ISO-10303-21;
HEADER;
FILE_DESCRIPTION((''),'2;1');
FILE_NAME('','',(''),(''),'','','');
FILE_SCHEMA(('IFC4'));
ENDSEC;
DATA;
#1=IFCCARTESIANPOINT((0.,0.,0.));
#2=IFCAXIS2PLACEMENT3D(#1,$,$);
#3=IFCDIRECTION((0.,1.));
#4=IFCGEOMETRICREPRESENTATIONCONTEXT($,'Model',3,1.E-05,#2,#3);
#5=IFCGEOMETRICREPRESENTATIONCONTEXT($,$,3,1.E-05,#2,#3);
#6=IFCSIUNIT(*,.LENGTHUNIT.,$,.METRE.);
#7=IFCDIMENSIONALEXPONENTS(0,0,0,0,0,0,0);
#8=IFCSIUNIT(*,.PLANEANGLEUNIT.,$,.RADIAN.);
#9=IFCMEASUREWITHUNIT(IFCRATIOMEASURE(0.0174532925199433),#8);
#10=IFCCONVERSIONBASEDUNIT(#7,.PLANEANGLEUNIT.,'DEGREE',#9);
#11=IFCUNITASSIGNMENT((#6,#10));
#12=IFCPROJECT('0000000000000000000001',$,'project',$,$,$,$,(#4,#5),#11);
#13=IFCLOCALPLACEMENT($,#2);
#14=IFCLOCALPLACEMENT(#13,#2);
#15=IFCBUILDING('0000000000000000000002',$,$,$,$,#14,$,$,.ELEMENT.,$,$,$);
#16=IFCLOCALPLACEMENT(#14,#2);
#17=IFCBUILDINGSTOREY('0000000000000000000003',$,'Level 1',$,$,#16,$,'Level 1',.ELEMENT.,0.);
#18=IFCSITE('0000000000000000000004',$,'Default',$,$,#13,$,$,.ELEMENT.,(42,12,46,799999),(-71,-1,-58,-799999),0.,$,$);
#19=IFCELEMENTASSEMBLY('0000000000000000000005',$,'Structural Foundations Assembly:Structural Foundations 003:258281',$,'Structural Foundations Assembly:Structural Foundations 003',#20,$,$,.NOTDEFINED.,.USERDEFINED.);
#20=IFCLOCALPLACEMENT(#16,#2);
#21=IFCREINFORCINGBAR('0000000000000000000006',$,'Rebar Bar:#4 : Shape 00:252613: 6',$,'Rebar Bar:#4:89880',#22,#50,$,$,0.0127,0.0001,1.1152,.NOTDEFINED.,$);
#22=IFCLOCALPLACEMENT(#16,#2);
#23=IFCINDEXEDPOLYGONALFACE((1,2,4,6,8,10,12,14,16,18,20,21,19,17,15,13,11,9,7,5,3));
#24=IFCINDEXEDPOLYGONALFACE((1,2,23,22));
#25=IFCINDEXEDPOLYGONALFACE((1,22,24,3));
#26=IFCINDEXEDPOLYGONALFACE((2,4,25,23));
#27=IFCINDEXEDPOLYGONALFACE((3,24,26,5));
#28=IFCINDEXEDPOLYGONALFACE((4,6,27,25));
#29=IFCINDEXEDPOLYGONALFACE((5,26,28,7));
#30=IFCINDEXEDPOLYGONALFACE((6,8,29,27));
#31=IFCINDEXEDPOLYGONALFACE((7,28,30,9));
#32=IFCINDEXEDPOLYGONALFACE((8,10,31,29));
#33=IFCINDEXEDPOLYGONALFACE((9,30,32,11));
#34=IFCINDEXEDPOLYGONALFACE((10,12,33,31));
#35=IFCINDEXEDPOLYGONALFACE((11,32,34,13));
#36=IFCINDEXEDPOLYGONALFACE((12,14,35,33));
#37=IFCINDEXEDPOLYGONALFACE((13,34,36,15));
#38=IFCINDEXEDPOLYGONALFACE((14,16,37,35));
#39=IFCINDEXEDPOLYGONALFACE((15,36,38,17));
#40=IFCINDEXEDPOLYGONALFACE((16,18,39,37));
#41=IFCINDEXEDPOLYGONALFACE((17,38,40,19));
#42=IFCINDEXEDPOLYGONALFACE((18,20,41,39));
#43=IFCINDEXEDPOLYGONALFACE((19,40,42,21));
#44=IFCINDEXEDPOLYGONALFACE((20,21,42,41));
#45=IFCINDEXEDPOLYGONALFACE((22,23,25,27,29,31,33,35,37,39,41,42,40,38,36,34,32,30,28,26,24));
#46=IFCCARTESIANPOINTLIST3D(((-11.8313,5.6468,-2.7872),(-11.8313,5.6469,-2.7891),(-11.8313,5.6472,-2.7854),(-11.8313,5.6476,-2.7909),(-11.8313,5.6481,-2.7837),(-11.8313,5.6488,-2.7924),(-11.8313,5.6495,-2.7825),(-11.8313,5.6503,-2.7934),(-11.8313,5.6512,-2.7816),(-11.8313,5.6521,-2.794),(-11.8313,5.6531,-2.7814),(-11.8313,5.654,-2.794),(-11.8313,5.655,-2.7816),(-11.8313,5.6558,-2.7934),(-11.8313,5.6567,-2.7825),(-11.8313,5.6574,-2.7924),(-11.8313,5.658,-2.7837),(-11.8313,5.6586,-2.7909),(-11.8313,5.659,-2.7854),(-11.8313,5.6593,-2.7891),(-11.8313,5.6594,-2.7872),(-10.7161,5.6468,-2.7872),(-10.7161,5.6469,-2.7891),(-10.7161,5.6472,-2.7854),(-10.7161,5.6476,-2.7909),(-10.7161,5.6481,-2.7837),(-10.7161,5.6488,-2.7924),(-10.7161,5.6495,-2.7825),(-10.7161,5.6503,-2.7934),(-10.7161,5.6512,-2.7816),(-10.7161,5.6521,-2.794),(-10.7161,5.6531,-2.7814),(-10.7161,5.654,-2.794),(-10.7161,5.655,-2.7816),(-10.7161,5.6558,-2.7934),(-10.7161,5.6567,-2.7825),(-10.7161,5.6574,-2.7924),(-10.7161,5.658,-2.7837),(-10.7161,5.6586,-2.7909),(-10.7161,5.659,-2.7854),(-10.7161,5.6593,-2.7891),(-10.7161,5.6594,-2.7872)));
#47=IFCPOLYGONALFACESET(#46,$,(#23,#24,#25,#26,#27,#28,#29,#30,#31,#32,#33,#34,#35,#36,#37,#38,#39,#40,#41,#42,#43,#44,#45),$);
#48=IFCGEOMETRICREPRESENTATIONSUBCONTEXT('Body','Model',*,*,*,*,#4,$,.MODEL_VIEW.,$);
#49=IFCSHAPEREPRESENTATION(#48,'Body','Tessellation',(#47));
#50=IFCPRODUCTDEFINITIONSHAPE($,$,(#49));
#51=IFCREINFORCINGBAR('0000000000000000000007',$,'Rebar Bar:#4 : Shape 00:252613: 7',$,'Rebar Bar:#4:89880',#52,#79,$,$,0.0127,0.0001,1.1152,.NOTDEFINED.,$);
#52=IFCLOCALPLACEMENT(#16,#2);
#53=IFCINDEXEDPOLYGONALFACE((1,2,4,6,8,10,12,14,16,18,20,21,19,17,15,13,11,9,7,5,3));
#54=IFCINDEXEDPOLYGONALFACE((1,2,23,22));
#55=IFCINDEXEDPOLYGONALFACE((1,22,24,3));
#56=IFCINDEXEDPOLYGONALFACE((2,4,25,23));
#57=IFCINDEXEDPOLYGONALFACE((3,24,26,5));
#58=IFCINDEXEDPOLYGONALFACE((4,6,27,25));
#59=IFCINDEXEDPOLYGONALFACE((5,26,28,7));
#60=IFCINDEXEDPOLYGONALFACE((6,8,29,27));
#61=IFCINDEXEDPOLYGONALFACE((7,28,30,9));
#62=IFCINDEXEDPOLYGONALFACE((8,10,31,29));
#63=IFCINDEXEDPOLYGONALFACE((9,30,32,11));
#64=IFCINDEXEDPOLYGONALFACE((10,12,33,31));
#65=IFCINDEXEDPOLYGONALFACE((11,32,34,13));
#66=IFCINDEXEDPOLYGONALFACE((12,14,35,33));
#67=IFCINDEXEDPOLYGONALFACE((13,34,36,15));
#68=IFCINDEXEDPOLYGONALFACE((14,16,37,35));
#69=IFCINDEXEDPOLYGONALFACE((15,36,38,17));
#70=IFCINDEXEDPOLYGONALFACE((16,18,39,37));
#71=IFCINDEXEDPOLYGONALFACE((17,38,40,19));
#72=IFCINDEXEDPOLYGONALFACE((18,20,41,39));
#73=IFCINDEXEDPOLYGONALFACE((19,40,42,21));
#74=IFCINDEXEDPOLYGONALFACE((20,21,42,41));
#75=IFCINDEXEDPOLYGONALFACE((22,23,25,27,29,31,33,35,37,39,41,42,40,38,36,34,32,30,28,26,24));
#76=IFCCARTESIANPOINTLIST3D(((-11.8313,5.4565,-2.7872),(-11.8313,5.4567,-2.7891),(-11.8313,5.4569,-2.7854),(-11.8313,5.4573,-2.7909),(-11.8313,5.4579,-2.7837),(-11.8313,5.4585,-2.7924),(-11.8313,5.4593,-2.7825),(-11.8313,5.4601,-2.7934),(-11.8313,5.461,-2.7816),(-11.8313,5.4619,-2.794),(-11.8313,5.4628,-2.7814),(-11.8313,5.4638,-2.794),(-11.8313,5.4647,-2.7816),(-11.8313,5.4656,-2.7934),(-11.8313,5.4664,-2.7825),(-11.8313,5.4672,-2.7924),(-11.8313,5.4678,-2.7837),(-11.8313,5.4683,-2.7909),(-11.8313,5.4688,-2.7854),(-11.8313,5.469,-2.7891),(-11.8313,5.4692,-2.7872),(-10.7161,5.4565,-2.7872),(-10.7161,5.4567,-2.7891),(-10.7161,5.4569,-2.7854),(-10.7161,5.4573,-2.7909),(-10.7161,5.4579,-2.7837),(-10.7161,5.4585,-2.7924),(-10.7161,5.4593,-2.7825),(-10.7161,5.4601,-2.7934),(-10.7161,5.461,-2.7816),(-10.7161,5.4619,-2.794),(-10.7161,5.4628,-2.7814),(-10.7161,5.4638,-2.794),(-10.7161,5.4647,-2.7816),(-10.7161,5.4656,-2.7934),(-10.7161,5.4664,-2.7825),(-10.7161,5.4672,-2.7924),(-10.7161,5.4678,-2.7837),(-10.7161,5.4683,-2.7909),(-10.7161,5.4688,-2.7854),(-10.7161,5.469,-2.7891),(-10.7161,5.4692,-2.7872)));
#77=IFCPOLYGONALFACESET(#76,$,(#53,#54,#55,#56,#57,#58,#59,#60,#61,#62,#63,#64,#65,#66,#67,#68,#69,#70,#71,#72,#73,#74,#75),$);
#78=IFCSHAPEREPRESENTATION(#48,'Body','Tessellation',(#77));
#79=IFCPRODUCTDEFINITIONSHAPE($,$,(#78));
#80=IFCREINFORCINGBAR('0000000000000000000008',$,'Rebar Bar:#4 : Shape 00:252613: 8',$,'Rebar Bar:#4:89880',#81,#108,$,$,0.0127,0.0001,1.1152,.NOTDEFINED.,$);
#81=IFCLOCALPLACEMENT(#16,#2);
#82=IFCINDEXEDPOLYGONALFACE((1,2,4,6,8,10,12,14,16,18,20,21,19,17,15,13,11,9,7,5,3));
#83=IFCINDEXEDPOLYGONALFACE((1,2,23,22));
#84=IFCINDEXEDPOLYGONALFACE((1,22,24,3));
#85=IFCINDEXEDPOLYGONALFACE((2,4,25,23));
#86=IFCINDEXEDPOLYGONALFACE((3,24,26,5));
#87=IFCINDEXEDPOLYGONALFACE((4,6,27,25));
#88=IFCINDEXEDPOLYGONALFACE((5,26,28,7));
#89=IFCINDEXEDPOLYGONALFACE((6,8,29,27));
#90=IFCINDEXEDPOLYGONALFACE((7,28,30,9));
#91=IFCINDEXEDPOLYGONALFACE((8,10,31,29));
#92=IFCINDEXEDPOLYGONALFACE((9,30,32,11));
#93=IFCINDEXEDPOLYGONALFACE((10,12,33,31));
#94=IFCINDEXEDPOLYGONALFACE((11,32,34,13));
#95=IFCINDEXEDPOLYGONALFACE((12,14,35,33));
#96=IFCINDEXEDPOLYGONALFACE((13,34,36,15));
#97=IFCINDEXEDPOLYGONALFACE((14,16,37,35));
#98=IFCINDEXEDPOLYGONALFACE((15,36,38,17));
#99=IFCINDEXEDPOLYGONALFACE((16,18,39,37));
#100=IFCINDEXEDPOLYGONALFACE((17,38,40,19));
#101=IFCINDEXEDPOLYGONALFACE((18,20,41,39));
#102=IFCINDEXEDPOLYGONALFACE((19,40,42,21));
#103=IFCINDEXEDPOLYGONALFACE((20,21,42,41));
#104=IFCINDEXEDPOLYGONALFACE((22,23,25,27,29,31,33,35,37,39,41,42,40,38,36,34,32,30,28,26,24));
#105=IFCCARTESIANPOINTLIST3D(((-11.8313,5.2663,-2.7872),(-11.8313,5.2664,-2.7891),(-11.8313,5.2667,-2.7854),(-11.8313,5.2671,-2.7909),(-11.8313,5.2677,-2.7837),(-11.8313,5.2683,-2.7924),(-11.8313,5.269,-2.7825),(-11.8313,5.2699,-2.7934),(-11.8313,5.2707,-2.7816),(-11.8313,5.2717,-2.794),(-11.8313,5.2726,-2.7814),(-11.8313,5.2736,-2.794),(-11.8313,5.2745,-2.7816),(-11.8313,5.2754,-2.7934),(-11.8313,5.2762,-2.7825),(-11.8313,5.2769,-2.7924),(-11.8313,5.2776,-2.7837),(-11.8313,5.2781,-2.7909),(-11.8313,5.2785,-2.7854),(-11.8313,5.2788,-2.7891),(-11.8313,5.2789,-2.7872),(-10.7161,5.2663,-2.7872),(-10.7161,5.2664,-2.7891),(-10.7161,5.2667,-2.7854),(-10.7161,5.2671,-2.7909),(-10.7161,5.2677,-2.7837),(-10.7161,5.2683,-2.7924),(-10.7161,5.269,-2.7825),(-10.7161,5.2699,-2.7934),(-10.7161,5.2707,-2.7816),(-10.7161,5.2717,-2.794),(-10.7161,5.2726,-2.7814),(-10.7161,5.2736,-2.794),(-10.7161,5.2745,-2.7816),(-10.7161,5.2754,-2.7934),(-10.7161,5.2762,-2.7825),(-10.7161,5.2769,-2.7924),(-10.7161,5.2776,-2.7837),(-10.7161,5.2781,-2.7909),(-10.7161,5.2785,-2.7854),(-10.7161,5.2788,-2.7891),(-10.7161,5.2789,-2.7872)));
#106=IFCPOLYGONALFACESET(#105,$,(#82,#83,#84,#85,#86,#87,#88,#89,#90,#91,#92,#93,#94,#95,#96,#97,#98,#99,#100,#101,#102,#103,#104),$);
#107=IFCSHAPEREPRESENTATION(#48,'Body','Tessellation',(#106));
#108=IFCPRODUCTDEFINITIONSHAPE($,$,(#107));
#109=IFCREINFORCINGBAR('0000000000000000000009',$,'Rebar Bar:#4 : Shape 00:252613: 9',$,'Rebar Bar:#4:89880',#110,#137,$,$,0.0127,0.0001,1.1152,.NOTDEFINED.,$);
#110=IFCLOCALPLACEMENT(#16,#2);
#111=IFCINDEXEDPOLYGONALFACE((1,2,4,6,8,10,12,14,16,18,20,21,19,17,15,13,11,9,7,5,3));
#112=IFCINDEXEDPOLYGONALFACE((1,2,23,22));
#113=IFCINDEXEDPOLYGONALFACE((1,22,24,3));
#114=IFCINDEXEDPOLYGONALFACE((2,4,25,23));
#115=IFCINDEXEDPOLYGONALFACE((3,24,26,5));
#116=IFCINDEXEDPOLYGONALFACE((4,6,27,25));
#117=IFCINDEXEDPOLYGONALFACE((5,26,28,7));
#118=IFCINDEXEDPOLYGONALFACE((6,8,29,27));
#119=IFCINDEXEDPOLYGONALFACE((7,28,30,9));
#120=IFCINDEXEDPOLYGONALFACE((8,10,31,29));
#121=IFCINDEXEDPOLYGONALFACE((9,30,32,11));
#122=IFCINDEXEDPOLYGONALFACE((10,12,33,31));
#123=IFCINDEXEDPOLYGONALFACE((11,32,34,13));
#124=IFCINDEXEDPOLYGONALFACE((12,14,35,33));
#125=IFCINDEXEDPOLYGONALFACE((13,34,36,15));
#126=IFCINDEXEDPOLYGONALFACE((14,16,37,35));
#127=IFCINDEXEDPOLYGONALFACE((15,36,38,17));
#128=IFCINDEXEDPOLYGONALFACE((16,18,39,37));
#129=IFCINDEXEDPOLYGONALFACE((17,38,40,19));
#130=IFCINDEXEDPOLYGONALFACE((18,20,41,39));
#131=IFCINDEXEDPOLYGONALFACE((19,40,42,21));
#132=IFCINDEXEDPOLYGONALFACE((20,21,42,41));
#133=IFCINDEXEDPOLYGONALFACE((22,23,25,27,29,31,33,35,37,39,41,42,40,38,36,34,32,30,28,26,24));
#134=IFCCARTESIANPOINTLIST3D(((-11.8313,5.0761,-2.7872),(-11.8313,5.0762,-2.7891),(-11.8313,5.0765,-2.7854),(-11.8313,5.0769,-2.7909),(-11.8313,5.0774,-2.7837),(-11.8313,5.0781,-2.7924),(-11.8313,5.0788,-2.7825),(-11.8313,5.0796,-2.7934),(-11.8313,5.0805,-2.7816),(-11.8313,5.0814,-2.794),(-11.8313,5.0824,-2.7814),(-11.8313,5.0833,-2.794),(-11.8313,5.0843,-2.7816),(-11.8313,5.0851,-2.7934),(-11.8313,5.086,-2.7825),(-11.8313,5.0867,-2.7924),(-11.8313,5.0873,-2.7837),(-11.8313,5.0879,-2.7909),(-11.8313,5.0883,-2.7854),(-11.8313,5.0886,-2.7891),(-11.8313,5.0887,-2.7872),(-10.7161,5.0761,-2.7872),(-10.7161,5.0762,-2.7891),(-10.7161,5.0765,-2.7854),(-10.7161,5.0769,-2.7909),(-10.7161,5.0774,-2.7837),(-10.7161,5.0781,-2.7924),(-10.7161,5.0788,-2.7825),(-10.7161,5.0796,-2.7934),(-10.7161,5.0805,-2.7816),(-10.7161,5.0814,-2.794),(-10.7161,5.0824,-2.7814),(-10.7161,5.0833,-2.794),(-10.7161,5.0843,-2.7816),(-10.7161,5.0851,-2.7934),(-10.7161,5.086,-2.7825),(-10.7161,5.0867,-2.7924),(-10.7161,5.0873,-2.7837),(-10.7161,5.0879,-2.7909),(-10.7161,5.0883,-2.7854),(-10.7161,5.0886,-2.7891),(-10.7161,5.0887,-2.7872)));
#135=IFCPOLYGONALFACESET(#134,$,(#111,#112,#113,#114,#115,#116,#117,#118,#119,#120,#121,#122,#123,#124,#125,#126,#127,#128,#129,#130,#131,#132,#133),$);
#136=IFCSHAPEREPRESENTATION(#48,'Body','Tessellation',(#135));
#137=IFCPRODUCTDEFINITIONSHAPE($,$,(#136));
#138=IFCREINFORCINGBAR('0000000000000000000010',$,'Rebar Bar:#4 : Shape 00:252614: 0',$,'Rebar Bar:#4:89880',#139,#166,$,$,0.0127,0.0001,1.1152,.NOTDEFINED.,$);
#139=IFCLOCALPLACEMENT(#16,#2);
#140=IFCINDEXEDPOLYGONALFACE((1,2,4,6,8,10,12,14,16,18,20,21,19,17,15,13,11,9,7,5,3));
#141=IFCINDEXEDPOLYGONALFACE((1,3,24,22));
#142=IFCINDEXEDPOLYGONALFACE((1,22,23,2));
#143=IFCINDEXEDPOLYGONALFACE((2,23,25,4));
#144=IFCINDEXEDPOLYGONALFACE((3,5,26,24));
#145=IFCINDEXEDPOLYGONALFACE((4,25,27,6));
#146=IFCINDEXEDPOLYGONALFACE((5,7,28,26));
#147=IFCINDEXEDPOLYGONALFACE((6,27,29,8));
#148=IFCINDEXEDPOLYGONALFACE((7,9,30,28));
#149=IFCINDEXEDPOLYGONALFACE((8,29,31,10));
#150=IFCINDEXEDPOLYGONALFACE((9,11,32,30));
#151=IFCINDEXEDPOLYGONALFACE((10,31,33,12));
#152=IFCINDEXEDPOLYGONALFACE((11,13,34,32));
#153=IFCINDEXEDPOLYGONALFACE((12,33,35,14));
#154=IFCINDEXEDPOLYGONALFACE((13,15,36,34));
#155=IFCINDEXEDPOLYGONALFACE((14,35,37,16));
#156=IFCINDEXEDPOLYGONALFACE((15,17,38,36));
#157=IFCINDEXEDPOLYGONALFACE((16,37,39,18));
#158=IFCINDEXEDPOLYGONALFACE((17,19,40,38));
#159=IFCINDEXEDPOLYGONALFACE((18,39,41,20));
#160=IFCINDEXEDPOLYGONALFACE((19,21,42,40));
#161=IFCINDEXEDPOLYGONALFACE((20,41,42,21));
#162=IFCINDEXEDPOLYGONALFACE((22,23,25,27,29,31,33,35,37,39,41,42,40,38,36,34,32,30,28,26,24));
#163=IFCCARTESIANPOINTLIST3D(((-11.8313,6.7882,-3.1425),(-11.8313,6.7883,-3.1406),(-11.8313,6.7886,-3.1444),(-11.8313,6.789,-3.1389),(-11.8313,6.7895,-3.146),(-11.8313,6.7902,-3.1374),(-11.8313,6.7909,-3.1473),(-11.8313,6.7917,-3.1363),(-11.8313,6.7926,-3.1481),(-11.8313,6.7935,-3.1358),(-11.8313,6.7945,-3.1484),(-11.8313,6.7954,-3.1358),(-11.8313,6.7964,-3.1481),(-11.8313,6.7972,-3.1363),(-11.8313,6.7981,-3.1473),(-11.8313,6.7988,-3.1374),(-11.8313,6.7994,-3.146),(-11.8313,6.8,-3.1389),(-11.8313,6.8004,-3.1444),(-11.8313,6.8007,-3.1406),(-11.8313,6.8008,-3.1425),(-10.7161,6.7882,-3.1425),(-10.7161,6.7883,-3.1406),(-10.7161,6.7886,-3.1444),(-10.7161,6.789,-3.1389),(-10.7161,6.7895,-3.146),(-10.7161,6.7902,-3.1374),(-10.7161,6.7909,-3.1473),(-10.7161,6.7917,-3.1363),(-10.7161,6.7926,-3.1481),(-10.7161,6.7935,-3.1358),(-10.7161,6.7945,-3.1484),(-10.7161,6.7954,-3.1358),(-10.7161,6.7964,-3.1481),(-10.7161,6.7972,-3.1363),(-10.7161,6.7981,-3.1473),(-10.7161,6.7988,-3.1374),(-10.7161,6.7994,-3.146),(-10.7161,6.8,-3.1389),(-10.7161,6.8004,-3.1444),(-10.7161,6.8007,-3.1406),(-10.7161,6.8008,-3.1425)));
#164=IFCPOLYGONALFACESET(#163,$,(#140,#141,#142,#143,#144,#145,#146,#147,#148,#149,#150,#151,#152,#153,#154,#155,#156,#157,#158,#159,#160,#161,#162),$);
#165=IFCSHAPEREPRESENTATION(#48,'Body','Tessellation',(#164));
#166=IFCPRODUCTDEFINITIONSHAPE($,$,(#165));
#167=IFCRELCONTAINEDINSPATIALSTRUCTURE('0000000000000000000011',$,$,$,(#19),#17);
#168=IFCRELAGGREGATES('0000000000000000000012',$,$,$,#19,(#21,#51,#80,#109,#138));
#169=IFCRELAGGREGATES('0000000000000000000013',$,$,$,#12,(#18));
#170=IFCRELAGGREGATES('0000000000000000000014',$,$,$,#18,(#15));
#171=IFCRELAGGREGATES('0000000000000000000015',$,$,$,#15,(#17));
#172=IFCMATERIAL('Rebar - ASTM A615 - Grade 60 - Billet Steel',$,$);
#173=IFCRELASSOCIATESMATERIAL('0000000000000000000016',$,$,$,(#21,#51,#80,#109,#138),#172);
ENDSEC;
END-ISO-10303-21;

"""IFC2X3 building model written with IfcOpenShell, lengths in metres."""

from ifc_helpers import new_model, entity, si_unit, converted_unit, direction, origin, place, context, subcontext, project, spatial, material, element, aggregate, save


model = new_model("IFC2X3")

# Units and contexts
model_context = context("Model", 3, precision=1e-05, world=origin(), true_north=direction((0.0, 1.0)))
context_of_model = context(None, 3, precision=1e-05, world=origin(), true_north=direction((0.0, 1.0)))
body_context = subcontext(model_context, "Body", "Model", "MODEL_VIEW")
ifc_project = project(units=[si_unit("LENGTHUNIT", "METRE"), converted_unit("PLANEANGLEUNIT", "DEGREE", entity("IfcRatioMeasure", 0.0174532925199433), si_unit("PLANEANGLEUNIT", "RADIAN"), dimensions=[0, 0, 0, 0, 0, 0, 0])], contexts=[model_context, context_of_model])

# Site, building, storey
site_placement = place(None, origin())
site = spatial("IfcSite", under=ifc_project, at=site_placement, Name="Default", CompositionType="ELEMENT", RefLatitude=(42, 12, 46, 799999), RefLongitude=(-71, -1, -58, -799999), RefElevation=0.0)
building_placement = place(site_placement, origin())
building = spatial("IfcBuilding", under=site, at=building_placement, CompositionType="ELEMENT")
storey_placement = place(building_placement, origin())
storey = spatial("IfcBuildingStorey", under=building, at=storey_placement, Name="Level 1", LongName="Level 1", CompositionType="ELEMENT", Elevation=0.0)

# Element assembly
assembly_1_placement = place(storey_placement, origin())
assembly_1 = element("IfcElementAssembly", 1, at=assembly_1_placement, inside=storey, Name="Structural Foundations Assembly:Structural Foundations 003:258281", ObjectType="Structural Foundations Assembly:Structural Foundations 003", AssemblyPlace="NOTDEFINED", PredefinedType="USERDEFINED")

# Shared definitions
ifc_material_1 = material(Name="Rebar - ASTM A615 - Grade 60 - Billet Steel")

# Reinforcing bars
reinforcing_bar_1_placement = place(assembly_1_placement, origin())
reinforcing_bar_1 = element("IfcReinforcingBar", 2, at=reinforcing_bar_1_placement, material=ifc_material_1, Name="Rebar Bar:#4 : Shape 00:252613: 6", ObjectType="Rebar Bar:#4:89880", BarLength=1.1152, BarRole="NOTDEFINED", CrossSectionArea=0.0001, NominalDiameter=0.0127, context=body_context, shape_type="AdvancedSweptSolid", body=[
    entity("IfcSweptDiskSolid", entity("IfcCompositeCurve", [entity("IfcCompositeCurveSegment", "CONTINUOUS", True, entity("IfcPolyline", [entity("IfcCartesianPoint", [-11.8313, 5.6531, -2.7877]), entity("IfcCartesianPoint", [-10.7161, 5.6531, -2.7877])]))], False), 0.0063, None, 0.0, 1.0),
])
reinforcing_bar_2_placement = place(assembly_1_placement, origin())
reinforcing_bar_2 = element("IfcReinforcingBar", 3, at=reinforcing_bar_2_placement, material=ifc_material_1, Name="Rebar Bar:#4 : Shape 00:252613: 7", ObjectType="Rebar Bar:#4:89880", BarLength=1.1152, BarRole="NOTDEFINED", CrossSectionArea=0.0001, NominalDiameter=0.0127, context=body_context, shape_type="AdvancedSweptSolid", body=[
    entity("IfcSweptDiskSolid", entity("IfcCompositeCurve", [entity("IfcCompositeCurveSegment", "CONTINUOUS", True, entity("IfcPolyline", [entity("IfcCartesianPoint", [-11.8313, 5.4628, -2.7877]), entity("IfcCartesianPoint", [-10.7161, 5.4628, -2.7877])]))], False), 0.0063, None, 0.0, 1.0),
])
reinforcing_bar_3_placement = place(assembly_1_placement, origin())
reinforcing_bar_3 = element("IfcReinforcingBar", 4, at=reinforcing_bar_3_placement, material=ifc_material_1, Name="Rebar Bar:#4 : Shape 00:252613: 8", ObjectType="Rebar Bar:#4:89880", BarLength=1.1152, BarRole="NOTDEFINED", CrossSectionArea=0.0001, NominalDiameter=0.0127, context=body_context, shape_type="AdvancedSweptSolid", body=[
    entity("IfcSweptDiskSolid", entity("IfcCompositeCurve", [entity("IfcCompositeCurveSegment", "CONTINUOUS", True, entity("IfcPolyline", [entity("IfcCartesianPoint", [-11.8313, 5.2726, -2.7877]), entity("IfcCartesianPoint", [-10.7161, 5.2726, -2.7877])]))], False), 0.0063, None, 0.0, 1.0),
])
reinforcing_bar_4_placement = place(assembly_1_placement, origin())
reinforcing_bar_4 = element("IfcReinforcingBar", 5, at=reinforcing_bar_4_placement, material=ifc_material_1, Name="Rebar Bar:#4 : Shape 00:252613: 9", ObjectType="Rebar Bar:#4:89880", BarLength=1.1152, BarRole="NOTDEFINED", CrossSectionArea=0.0001, NominalDiameter=0.0127, context=body_context, shape_type="AdvancedSweptSolid", body=[
    entity("IfcSweptDiskSolid", entity("IfcCompositeCurve", [entity("IfcCompositeCurveSegment", "CONTINUOUS", True, entity("IfcPolyline", [entity("IfcCartesianPoint", [-11.8313, 5.0824, -2.7877]), entity("IfcCartesianPoint", [-10.7161, 5.0824, -2.7877])]))], False), 0.0063, None, 0.0, 1.0),
])
reinforcing_bar_5_placement = place(assembly_1_placement, origin())
reinforcing_bar_5 = element("IfcReinforcingBar", 6, at=reinforcing_bar_5_placement, material=ifc_material_1, Name="Rebar Bar:#4 : Shape 00:252614: 0", ObjectType="Rebar Bar:#4:89880", BarLength=1.1152, BarRole="NOTDEFINED", CrossSectionArea=0.0001, NominalDiameter=0.0127, context=body_context, shape_type="AdvancedSweptSolid", body=[
    entity("IfcSweptDiskSolid", entity("IfcCompositeCurve", [entity("IfcCompositeCurveSegment", "CONTINUOUS", True, entity("IfcPolyline", [entity("IfcCartesianPoint", [-10.7161, 6.7945, -3.142]), entity("IfcCartesianPoint", [-11.8313, 6.7945, -3.142])]))], False), 0.0063, None, 0.0, 1.0),
])
aggregate(assembly_1, [reinforcing_bar_1, reinforcing_bar_2, reinforcing_bar_3, reinforcing_bar_4, reinforcing_bar_5])

save(model, "model.ifc")
